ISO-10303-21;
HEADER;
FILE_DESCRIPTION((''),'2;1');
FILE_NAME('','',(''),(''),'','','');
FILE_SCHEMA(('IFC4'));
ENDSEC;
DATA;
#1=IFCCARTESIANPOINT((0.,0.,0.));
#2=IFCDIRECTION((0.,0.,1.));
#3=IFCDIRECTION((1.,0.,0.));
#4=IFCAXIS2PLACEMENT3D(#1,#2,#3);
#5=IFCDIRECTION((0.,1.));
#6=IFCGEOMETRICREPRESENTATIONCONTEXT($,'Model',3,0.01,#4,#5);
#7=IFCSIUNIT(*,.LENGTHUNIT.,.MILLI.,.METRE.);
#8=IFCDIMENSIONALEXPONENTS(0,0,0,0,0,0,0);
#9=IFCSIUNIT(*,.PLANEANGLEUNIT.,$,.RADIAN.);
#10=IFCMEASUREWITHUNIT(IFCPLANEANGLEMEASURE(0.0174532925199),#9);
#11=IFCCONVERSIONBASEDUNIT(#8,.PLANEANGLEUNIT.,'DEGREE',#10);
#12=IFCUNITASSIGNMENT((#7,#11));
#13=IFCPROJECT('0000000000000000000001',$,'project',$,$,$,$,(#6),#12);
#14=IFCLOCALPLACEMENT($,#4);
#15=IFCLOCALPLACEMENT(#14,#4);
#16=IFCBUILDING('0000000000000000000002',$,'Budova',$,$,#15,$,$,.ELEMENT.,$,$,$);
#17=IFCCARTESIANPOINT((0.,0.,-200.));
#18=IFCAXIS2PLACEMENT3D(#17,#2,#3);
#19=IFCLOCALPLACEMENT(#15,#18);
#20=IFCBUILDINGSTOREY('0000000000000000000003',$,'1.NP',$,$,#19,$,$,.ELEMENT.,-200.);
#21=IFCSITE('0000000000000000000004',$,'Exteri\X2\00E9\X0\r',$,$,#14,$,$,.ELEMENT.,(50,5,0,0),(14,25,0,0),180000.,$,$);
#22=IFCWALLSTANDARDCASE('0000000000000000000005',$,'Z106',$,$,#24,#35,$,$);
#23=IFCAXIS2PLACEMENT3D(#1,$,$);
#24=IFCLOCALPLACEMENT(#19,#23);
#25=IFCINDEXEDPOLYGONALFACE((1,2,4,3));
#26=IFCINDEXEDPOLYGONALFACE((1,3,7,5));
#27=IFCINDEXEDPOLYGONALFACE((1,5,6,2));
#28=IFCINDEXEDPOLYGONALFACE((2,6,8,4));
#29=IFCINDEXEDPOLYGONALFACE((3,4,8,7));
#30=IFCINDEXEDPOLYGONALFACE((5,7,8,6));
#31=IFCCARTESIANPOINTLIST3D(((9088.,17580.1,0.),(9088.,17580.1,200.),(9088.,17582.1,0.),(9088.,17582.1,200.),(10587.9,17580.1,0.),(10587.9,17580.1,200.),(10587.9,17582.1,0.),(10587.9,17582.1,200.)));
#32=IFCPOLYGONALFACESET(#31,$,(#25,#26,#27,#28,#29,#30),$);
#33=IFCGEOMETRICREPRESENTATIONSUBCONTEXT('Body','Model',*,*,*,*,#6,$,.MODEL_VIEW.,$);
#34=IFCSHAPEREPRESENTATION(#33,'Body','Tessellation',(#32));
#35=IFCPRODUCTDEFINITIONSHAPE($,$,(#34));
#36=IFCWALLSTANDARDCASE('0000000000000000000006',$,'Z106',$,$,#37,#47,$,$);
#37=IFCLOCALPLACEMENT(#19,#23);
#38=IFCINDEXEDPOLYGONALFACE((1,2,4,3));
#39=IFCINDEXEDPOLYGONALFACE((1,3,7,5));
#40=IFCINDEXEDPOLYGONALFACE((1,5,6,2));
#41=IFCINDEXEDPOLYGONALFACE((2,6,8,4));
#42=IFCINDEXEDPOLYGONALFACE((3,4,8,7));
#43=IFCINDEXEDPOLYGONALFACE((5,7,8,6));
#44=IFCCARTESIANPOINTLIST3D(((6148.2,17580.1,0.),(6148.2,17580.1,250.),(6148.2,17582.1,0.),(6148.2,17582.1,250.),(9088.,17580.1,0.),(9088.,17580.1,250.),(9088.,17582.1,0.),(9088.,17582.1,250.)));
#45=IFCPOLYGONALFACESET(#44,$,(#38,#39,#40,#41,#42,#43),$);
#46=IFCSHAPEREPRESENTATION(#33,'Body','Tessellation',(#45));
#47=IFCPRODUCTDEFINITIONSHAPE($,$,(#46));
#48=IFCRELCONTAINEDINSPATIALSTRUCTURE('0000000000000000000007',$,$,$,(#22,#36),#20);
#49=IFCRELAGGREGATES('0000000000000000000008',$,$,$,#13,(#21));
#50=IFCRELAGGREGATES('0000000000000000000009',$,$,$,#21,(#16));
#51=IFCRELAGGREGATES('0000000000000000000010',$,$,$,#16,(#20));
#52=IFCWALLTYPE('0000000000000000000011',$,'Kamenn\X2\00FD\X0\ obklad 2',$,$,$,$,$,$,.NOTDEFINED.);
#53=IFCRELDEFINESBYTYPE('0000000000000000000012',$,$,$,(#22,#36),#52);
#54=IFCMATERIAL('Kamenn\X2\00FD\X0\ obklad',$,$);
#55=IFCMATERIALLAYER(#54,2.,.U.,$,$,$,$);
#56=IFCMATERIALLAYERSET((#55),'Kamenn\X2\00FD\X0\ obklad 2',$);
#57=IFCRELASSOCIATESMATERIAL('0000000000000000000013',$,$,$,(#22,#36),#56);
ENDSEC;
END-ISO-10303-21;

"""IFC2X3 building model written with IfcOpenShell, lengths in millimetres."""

from ifc_helpers import new_model, entity, si_unit, converted_unit, direction, frame, origin_with_axes, place, context, subcontext, project, spatial, polyline, outline, extrude, material, layer, layer_set, layer_usage, type_object, element, save


model = new_model("IFC2X3")

# Units and contexts
model_context = context("Model", 3, precision=0.01, world=origin_with_axes(), true_north=direction((0.0, 1.0)))
body_context = subcontext(model_context, "Body", "Model", "MODEL_VIEW")
ifc_project = project(units=[si_unit("LENGTHUNIT", "METRE", prefix="MILLI"), converted_unit("PLANEANGLEUNIT", "DEGREE", entity("IfcPlaneAngleMeasure", 0.0174532925199), si_unit("PLANEANGLEUNIT", "RADIAN"), dimensions=[0, 0, 0, 0, 0, 0, 0])], contexts=[model_context])

# Site, building, storey
site_placement = place(None, origin_with_axes())
site = spatial("IfcSite", under=ifc_project, at=site_placement, Name="Exteriér", CompositionType="ELEMENT", RefLatitude=(50, 5, 0, 0), RefLongitude=(14, 25, 0, 0), RefElevation=180000.0)
building_placement = place(site_placement, origin_with_axes())
building = spatial("IfcBuilding", under=site, at=building_placement, Name="Budova", CompositionType="ELEMENT")
storey_placement = place(building_placement, frame((0.0, 0.0, -200.0), z_axis=(0.0, 0.0, 1.0), x_axis=(1.0, 0.0, 0.0)))
storey = spatial("IfcBuildingStorey", under=building, at=storey_placement, Name="1.NP", CompositionType="ELEMENT", Elevation=-200.0)

# Walls
ifc_material_1 = material(Name="Kamenný obklad")
ifc_layer_1 = layer(ifc_material_1, 2.0, ventilated="UNKNOWN")
ifc_layer_set_1 = layer_set([ifc_layer_1], Name="Kamenný obklad 2")
wall_type_1 = type_object("IfcWallType", Name="Kamenný obklad 2", PredefinedType="NOTDEFINED")
ifc_layer_usage_1 = layer_usage(ifc_layer_set_1, "AXIS2", "POSITIVE", -2.0)
wall_1_placement = place(storey_placement, frame((10587.9, 17580.1, 0.0), z_axis=(0.0, 0.0, 1.0), x_axis=(-1.0, 0.0, 0.0)))
element("IfcWallStandardCase", 1, at=wall_1_placement, inside=storey, type_object=wall_type_1, material=ifc_layer_usage_1, Name="Z106", context=body_context, shape_type="SweptSolid", body=[
    extrude(outline(polyline([(0.0, -2.0), (1499.9, -2.0), (1499.9, 0.0), (0.0, 0.0), (0.0, -2.0)])), origin_with_axes(), (0.0, 0.0, 1.0), 200.0),
])
ifc_layer_usage_2 = layer_usage(ifc_layer_set_1, "AXIS2", "POSITIVE", -2.0)
wall_2_placement = place(storey_placement, frame((9088.0, 17580.1, 0.0), z_axis=(0.0, 0.0, 1.0), x_axis=(-1.0, 0.0, 0.0)))
element("IfcWallStandardCase", 2, at=wall_2_placement, inside=storey, type_object=wall_type_1, material=ifc_layer_usage_2, Name="Z106", context=body_context, shape_type="SweptSolid", body=[
    extrude(outline(polyline([(0.0, -2.0), (2939.8, -2.0), (2939.8, 0.0), (0.0, 0.0), (0.0, -2.0)])), origin_with_axes(), (0.0, 0.0, 1.0), 250.0),
])

save(model, "model.ifc")
